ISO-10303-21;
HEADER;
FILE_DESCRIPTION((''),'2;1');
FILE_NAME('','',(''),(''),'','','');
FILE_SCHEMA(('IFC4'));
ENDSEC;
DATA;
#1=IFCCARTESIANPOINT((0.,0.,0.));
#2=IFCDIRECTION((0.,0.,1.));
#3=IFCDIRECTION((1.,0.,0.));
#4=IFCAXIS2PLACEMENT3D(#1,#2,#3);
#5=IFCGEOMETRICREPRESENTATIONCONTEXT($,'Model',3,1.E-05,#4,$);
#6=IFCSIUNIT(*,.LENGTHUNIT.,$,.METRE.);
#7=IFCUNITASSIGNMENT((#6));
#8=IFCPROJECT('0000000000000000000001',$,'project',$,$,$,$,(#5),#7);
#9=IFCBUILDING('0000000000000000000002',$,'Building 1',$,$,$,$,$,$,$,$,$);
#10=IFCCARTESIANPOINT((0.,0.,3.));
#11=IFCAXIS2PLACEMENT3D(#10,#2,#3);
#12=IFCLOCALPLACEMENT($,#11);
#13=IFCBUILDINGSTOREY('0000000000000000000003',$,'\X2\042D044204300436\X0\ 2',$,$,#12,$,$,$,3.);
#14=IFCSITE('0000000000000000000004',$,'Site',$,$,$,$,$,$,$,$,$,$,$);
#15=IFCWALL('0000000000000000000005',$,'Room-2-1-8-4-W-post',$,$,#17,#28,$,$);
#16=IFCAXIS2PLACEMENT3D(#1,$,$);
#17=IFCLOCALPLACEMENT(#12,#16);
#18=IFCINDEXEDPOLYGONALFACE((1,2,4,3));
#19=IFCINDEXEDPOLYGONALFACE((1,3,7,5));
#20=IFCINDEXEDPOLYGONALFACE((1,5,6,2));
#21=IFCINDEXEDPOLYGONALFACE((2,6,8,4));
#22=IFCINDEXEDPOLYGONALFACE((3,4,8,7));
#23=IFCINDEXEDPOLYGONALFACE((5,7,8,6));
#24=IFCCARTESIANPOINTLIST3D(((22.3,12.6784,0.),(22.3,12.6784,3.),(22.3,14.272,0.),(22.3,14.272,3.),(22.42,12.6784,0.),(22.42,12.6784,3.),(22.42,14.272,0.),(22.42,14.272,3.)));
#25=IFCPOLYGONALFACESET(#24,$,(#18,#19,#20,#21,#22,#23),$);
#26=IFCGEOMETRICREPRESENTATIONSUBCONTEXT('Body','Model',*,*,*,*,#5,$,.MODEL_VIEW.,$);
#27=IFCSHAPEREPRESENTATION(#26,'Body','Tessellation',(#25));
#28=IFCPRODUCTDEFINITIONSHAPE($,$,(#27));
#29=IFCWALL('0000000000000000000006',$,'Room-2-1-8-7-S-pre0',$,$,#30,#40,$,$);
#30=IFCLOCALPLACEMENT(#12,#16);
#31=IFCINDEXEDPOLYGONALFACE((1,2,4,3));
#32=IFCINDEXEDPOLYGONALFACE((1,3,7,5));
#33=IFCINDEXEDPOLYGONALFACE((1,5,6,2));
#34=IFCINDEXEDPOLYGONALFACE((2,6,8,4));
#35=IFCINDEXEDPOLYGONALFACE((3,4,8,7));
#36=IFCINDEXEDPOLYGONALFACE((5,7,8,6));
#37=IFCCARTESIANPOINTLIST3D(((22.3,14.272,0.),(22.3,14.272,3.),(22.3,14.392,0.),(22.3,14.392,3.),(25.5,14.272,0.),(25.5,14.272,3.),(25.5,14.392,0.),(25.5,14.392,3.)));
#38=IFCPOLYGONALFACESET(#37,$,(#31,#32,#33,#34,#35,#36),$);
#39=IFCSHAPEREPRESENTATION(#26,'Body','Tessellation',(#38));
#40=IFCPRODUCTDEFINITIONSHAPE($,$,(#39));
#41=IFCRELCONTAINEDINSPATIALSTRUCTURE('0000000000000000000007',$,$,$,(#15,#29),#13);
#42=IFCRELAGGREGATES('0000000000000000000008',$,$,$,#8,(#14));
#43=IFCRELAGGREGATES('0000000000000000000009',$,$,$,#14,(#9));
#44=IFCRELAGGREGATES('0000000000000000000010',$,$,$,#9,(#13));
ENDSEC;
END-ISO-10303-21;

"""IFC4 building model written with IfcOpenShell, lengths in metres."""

from ifc_helpers import new_model, si_unit, frame, origin_with_axes, place, context, subcontext, project, spatial, indexed_curve, outline, extrude, element, save


model = new_model("IFC4")

# Units and contexts
model_context = context("Model", 3, precision=1e-05, world=origin_with_axes())
body_context = subcontext(model_context, "Body", "Model", "MODEL_VIEW")
ifc_project = project(units=[si_unit("LENGTHUNIT", "METRE")], contexts=[model_context])

# Site, building, storey
site = spatial("IfcSite", under=ifc_project, Name="Site")
building = spatial("IfcBuilding", under=site, Name="Building 1")
storey_placement = place(None, frame((0.0, 0.0, 3.0), z_axis=(0.0, 0.0, 1.0), x_axis=(1.0, 0.0, 0.0)))
storey = spatial("IfcBuildingStorey", under=building, at=storey_placement, Name="Этаж 2", Elevation=3.0)

# Walls
wall_1_placement = place(storey_placement, frame((22.3, 14.272, 0.0), z_axis=(0.0, 0.0, 1.0), x_axis=(0.0, -1.0, 0.0)))
element("IfcWall", 1, at=wall_1_placement, inside=storey, Name="Room-2-1-8-4-W-post", context=body_context, shape_type="SweptSolid", body=[
    extrude(outline(indexed_curve([(0.0, 0.0), (0.0, 0.12), (1.5936, 0.12), (1.5936, 0.0), (0.0, 0.0)], self_intersect=False)), origin_with_axes(), (0.0, 0.0, 1.0), 3.0),
])
wall_2_placement = place(storey_placement, frame((22.3, 14.272, 0.0), z_axis=(0.0, 0.0, 1.0), x_axis=(1.0, 0.0, 0.0)))
element("IfcWall", 2, at=wall_2_placement, inside=storey, Name="Room-2-1-8-7-S-pre0", context=body_context, shape_type="SweptSolid", body=[
    extrude(outline(indexed_curve([(0.0, 0.0), (0.0, 0.12), (3.2, 0.12), (3.2, 0.0), (0.0, 0.0)], self_intersect=False)), origin_with_axes(), (0.0, 0.0, 1.0), 3.0),
])

save(model, "model.ifc")
